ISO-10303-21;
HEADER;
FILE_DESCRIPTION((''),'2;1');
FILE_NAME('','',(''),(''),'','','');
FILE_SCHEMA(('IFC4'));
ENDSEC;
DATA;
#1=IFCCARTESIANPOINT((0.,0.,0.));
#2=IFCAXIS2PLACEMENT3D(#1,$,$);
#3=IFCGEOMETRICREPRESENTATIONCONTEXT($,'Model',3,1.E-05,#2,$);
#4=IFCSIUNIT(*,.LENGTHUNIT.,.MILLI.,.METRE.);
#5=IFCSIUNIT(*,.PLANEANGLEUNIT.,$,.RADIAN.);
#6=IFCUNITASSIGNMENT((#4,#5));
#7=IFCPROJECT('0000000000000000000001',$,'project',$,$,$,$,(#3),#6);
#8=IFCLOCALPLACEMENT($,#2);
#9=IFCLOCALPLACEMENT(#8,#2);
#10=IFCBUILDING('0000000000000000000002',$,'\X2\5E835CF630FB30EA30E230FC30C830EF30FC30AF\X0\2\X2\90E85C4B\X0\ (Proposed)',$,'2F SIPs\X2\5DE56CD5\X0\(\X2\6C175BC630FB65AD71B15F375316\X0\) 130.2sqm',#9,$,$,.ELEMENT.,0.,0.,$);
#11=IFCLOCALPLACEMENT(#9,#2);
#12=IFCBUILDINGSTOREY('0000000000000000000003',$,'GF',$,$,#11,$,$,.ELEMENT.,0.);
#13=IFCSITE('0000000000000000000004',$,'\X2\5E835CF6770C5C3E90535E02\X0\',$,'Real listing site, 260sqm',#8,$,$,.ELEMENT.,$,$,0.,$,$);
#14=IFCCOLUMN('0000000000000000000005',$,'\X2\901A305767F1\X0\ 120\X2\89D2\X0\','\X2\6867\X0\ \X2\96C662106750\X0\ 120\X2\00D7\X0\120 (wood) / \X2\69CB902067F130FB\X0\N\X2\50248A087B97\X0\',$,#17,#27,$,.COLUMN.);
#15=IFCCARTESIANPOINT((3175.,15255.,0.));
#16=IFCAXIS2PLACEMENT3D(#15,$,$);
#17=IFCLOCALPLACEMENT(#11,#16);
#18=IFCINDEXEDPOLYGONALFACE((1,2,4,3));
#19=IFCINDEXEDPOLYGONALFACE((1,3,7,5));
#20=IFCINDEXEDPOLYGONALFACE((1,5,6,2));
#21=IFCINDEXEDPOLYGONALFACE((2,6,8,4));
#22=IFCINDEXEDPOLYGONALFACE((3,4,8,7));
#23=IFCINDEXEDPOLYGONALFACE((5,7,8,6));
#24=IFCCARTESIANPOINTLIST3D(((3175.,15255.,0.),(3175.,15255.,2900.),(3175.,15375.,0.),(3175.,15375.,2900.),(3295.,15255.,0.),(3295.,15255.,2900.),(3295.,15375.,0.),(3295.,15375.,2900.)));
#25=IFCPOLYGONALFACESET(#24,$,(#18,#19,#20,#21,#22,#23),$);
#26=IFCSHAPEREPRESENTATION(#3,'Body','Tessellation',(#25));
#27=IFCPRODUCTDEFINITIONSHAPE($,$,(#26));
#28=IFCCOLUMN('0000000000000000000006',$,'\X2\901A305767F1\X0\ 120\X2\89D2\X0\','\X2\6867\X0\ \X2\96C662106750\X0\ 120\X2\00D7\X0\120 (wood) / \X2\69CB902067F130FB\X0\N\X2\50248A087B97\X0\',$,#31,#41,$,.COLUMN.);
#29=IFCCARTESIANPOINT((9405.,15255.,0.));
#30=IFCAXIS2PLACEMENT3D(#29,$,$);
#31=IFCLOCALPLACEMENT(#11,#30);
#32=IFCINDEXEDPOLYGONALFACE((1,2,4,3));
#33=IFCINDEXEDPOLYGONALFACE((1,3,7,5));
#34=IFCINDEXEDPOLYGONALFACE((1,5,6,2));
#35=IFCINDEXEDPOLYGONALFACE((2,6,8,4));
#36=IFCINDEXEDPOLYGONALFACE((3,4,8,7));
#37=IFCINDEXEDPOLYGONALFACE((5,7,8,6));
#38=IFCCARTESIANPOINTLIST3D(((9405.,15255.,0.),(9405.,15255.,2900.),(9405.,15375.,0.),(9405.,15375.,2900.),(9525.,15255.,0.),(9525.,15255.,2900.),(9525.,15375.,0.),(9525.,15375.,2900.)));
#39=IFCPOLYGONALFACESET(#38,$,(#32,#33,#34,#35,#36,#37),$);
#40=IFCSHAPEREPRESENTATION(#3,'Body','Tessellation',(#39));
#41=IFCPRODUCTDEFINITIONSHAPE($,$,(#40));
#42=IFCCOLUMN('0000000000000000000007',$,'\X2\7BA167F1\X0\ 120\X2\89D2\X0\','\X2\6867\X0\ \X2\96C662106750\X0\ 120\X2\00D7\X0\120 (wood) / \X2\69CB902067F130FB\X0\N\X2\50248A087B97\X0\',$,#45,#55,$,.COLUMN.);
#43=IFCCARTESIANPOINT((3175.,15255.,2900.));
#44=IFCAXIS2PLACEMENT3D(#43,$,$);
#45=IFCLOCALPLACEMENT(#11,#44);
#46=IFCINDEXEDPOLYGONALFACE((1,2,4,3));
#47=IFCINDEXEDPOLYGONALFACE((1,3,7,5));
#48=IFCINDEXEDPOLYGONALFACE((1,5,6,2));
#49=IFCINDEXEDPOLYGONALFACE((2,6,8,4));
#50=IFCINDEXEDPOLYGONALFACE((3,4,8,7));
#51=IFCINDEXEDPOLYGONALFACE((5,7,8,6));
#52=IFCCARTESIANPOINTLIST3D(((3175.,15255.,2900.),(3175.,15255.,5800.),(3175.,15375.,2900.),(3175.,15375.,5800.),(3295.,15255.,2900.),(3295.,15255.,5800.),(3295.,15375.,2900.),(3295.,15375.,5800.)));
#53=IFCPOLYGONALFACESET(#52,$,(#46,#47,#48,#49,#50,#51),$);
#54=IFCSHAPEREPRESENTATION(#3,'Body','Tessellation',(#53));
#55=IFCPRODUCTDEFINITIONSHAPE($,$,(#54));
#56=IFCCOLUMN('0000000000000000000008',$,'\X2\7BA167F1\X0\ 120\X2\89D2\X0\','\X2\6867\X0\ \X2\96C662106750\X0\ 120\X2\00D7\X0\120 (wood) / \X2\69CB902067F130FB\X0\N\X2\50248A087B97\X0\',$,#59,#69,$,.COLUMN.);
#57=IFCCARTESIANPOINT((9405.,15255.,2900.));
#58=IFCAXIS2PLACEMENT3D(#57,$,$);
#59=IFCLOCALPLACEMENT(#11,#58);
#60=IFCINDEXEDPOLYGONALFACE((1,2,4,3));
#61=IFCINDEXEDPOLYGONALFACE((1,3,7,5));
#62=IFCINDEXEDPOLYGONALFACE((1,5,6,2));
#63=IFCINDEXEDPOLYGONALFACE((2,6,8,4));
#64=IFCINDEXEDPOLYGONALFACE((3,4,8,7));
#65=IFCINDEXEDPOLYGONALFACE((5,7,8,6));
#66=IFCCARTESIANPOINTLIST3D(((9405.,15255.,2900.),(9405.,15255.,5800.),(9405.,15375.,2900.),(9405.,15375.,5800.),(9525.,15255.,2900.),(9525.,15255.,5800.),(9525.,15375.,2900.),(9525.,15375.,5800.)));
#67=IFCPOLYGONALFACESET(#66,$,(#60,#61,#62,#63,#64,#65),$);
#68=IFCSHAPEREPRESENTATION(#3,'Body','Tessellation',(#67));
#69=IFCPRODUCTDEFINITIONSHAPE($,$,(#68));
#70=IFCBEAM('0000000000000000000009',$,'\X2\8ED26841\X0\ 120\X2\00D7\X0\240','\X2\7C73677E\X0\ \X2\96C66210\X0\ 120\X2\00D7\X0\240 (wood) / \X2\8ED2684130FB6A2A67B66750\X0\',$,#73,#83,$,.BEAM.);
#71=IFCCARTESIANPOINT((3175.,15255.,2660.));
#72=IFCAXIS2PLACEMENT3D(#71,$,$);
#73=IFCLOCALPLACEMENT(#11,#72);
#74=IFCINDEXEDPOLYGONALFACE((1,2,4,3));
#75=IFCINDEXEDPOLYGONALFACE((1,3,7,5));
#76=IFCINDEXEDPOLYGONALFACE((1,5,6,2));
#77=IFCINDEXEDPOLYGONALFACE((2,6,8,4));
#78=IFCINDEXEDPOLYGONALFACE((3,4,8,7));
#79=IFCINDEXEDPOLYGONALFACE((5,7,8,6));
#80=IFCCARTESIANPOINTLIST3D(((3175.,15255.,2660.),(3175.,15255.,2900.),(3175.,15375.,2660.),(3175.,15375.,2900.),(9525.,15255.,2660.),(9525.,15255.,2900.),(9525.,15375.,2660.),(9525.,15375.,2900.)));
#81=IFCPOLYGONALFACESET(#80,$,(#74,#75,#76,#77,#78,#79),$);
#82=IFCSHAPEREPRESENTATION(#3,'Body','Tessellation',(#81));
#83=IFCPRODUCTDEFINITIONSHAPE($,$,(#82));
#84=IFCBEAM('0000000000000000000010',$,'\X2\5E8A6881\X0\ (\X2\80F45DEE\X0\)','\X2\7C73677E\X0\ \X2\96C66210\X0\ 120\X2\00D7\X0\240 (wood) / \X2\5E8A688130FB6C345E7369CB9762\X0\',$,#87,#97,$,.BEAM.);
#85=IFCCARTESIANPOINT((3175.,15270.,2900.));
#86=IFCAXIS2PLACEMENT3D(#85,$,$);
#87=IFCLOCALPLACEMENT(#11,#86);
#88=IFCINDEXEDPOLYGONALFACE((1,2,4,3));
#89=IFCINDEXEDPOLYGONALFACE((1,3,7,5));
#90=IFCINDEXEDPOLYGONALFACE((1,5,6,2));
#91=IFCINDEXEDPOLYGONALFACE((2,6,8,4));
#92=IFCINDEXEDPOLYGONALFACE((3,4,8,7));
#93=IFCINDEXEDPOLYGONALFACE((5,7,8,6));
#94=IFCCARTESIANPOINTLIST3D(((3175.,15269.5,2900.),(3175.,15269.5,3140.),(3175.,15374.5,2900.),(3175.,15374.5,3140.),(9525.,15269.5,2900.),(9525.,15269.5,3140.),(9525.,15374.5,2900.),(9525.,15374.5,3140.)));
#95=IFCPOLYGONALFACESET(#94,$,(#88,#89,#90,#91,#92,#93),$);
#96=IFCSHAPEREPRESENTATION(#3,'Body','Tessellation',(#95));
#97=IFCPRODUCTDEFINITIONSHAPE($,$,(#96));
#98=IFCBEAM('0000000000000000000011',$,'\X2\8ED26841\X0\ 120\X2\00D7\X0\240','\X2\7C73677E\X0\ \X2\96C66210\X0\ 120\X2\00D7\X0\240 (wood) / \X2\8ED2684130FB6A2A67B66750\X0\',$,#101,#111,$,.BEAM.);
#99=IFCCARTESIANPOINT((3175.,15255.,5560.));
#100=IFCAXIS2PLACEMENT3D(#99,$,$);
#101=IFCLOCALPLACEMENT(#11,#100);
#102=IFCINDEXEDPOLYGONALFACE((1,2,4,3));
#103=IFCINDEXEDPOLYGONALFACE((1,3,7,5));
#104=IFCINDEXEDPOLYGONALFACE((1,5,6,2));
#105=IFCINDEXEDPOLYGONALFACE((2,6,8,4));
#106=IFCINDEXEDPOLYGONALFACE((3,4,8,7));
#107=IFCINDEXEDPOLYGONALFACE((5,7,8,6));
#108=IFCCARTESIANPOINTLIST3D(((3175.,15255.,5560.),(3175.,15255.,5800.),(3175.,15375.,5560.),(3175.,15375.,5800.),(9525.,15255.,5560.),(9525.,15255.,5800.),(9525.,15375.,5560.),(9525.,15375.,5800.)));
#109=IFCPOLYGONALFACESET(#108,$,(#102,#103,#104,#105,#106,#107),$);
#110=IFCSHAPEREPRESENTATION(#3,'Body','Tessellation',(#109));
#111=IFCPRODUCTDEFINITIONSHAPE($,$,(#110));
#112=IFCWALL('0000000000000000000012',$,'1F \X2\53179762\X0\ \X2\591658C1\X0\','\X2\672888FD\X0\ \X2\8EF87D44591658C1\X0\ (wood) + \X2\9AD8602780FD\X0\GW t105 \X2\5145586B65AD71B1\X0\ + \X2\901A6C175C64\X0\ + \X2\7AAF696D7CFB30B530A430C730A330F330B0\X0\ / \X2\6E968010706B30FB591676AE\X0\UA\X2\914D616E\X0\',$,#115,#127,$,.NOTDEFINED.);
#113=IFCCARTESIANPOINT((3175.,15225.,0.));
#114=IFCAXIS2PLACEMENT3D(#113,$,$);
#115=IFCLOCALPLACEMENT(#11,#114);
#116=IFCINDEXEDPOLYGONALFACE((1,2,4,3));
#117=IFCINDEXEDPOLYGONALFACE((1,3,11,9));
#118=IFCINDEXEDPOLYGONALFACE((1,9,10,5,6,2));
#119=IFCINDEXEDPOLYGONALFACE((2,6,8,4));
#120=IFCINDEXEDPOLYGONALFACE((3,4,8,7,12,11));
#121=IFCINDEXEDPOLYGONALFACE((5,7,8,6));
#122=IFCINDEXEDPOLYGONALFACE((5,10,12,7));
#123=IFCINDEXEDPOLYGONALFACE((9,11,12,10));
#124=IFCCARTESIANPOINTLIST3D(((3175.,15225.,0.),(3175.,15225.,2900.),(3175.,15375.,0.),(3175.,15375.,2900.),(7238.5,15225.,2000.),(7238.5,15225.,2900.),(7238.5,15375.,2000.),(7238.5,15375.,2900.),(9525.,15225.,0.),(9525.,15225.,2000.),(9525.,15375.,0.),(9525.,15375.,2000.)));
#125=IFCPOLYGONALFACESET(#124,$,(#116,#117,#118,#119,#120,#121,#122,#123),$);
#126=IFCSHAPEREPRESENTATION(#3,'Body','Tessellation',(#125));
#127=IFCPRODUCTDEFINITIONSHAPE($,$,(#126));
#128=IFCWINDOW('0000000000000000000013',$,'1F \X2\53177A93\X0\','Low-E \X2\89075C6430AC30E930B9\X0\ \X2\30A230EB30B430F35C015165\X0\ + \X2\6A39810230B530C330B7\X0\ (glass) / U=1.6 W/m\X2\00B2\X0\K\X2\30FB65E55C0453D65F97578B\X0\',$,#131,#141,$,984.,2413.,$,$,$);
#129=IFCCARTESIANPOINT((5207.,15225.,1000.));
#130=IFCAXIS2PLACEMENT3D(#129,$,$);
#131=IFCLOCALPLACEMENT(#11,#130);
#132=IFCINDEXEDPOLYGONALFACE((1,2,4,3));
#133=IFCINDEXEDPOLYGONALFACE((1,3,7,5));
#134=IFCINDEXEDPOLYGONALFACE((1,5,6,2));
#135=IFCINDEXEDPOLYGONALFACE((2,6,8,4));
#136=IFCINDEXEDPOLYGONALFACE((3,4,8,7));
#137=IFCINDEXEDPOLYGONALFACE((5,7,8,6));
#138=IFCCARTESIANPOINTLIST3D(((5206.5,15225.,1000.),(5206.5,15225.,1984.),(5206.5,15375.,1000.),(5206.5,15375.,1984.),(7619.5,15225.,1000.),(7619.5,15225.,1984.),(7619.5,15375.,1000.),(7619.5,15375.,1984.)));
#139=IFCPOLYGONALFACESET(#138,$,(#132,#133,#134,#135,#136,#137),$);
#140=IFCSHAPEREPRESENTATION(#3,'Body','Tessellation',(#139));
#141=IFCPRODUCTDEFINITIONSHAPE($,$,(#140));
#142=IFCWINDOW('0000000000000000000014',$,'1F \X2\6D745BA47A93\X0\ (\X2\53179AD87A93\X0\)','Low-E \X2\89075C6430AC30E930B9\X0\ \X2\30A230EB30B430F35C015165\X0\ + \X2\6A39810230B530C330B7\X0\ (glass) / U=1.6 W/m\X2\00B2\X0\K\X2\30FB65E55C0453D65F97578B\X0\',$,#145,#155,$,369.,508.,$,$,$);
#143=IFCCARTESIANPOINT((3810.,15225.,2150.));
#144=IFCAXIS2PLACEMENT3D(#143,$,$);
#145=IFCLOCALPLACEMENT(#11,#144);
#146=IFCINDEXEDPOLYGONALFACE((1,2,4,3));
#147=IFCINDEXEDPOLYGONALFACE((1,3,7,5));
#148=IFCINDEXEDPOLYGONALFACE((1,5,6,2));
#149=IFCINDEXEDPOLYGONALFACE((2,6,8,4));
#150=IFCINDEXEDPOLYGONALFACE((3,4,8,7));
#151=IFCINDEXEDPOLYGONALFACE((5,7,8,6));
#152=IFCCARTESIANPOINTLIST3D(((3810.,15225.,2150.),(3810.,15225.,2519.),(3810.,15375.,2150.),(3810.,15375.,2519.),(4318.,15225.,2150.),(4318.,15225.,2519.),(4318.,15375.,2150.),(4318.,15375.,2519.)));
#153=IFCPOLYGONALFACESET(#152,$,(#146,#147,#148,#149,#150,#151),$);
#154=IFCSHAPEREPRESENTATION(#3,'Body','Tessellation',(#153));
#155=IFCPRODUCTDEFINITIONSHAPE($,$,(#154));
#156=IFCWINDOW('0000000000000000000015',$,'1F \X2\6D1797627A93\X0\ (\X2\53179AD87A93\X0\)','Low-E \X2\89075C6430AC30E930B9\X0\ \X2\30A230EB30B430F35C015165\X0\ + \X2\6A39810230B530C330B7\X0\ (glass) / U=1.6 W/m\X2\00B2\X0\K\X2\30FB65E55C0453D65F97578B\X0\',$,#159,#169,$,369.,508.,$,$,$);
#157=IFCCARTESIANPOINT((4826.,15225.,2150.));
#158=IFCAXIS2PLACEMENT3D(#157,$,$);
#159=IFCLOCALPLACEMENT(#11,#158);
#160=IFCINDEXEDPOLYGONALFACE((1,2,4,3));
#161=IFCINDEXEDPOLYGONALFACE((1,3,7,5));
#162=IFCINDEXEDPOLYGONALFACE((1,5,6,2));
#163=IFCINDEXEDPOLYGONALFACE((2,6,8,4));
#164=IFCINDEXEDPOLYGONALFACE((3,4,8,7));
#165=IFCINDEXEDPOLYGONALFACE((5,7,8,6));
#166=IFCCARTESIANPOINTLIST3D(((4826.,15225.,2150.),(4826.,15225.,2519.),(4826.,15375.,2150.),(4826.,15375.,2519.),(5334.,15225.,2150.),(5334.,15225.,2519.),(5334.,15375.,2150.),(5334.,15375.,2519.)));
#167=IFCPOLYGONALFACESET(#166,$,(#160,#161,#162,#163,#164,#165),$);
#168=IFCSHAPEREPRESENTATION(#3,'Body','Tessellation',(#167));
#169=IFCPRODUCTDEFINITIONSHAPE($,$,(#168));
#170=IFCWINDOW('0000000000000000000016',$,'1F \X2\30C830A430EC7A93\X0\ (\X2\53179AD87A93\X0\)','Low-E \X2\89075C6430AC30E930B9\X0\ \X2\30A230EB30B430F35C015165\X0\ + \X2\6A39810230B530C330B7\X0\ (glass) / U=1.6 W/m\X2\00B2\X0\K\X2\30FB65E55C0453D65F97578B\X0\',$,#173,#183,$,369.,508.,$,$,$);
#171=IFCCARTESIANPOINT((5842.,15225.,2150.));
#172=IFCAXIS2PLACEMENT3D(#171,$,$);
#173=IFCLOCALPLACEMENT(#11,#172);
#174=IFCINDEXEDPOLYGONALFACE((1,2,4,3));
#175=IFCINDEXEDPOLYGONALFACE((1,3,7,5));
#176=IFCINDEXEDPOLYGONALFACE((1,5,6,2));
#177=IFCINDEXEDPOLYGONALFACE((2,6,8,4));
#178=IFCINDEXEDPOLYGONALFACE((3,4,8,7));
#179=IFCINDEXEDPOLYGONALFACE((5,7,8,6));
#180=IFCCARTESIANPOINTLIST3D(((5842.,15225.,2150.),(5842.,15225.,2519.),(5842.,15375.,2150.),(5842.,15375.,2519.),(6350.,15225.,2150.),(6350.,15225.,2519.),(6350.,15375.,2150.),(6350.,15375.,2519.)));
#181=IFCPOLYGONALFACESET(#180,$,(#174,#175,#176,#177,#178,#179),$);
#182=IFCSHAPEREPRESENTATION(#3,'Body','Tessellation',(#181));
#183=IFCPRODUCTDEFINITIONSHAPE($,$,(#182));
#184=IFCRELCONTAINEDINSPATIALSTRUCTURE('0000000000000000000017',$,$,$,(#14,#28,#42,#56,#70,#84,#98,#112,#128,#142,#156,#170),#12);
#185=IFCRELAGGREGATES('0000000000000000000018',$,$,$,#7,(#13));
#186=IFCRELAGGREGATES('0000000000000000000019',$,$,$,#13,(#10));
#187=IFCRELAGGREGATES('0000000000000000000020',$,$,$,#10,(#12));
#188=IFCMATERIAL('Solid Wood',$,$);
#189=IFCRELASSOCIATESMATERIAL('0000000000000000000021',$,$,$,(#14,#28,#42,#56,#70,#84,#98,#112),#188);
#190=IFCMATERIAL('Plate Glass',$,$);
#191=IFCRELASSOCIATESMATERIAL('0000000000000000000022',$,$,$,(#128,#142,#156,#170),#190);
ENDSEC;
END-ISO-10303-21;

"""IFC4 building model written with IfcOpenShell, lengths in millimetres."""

from ifc_helpers import new_model, si_unit, frame, frame_2d, origin, place, context, project, spatial, rectangle, extrude, material, element, fill, save


model = new_model("IFC4")

# Units and contexts
model_context = context("Model", 3, precision=1e-05, world=origin())
ifc_project = project(units=[si_unit("LENGTHUNIT", "METRE", prefix="MILLI"), si_unit("PLANEANGLEUNIT", "RADIAN")], contexts=[model_context])

# Site, building, storey
site_placement = place(None, origin())
site = spatial("IfcSite", under=ifc_project, at=site_placement, Name="広島県尾道市", ObjectType="Real listing site, 260sqm", CompositionType="ELEMENT", RefElevation=0.0)
building_placement = place(site_placement, origin())
building = spatial("IfcBuilding", under=site, at=building_placement, Name="広島・リモートワーク2部屋 (Proposed)", ObjectType="2F SIPs工法(気密・断熱強化) 130.2sqm", CompositionType="ELEMENT", ElevationOfRefHeight=0.0, ElevationOfTerrain=0.0)
storey_placement = place(building_placement, origin())
storey = spatial("IfcBuildingStorey", under=building, at=storey_placement, Name="GF", CompositionType="ELEMENT", Elevation=0.0)

# Columns
ifc_material_1 = material(Name="Solid Wood")
column_1_placement = place(storey_placement, frame((3175.0, 15255.0, 0.0)))
element("IfcColumn", 1, at=column_1_placement, inside=storey, material=ifc_material_1, Name="通し柱 120角", Description="桧 集成材 120×120 (wood) / 構造柱・N値計算", PredefinedType="COLUMN", context=model_context, shape_type="SweptSolid", body=[
    extrude(rectangle(XDim=120.0, YDim=120.0, at=frame_2d((60.0, 60.0))), frame((3175.0, 15255.0, 0.0)), (0.0, 0.0, 1.0), 2900.0),
])
column_2_placement = place(storey_placement, frame((9405.0, 15255.0, 0.0)))
element("IfcColumn", 2, at=column_2_placement, inside=storey, material=ifc_material_1, Name="通し柱 120角", Description="桧 集成材 120×120 (wood) / 構造柱・N値計算", PredefinedType="COLUMN", context=model_context, shape_type="SweptSolid", body=[
    extrude(rectangle(XDim=120.0, YDim=120.0, at=frame_2d((60.0, 60.0))), frame((9405.0, 15255.0, 0.0)), (0.0, 0.0, 1.0), 2900.0),
])
column_3_placement = place(storey_placement, frame((3175.0, 15255.0, 2900.0)))
element("IfcColumn", 3, at=column_3_placement, inside=storey, material=ifc_material_1, Name="管柱 120角", Description="桧 集成材 120×120 (wood) / 構造柱・N値計算", PredefinedType="COLUMN", context=model_context, shape_type="SweptSolid", body=[
    extrude(rectangle(XDim=120.0, YDim=120.0, at=frame_2d((60.0, 60.0))), frame((3175.0, 15255.0, 2900.0)), (0.0, 0.0, 1.0), 2900.0),
])
column_4_placement = place(storey_placement, frame((9405.0, 15255.0, 2900.0)))
element("IfcColumn", 4, at=column_4_placement, inside=storey, material=ifc_material_1, Name="管柱 120角", Description="桧 集成材 120×120 (wood) / 構造柱・N値計算", PredefinedType="COLUMN", context=model_context, shape_type="SweptSolid", body=[
    extrude(rectangle(XDim=120.0, YDim=120.0, at=frame_2d((60.0, 60.0))), frame((9405.0, 15255.0, 2900.0)), (0.0, 0.0, 1.0), 2900.0),
])

# Beams
beam_1_placement = place(storey_placement, frame((3175.0, 15255.0, 2660.0)))
element("IfcBeam", 5, at=beam_1_placement, inside=storey, material=ifc_material_1, Name="軒桁 120×240", Description="米松 集成 120×240 (wood) / 軒桁・横架材", PredefinedType="BEAM", context=model_context, shape_type="SweptSolid", body=[
    extrude(rectangle(XDim=6350.0, YDim=120.0, at=frame_2d((3175.0, 60.0))), frame((3175.0, 15255.0, 2660.0)), (0.0, 0.0, 1.0), 240.0),
])
beam_2_placement = place(storey_placement, frame((3175.0, 15270.0, 2900.0)))
element("IfcBeam", 6, at=beam_2_placement, inside=storey, material=ifc_material_1, Name="床梁 (胴差)", Description="米松 集成 120×240 (wood) / 床梁・水平構面", PredefinedType="BEAM", context=model_context, shape_type="SweptSolid", body=[
    extrude(rectangle(XDim=6350.0, YDim=105.0, at=frame_2d((3175.0, 52.0))), frame((3175.0, 15270.0, 2900.0)), (0.0, 0.0, 1.0), 240.0),
])
beam_3_placement = place(storey_placement, frame((3175.0, 15255.0, 5560.0)))
element("IfcBeam", 7, at=beam_3_placement, inside=storey, material=ifc_material_1, Name="軒桁 120×240", Description="米松 集成 120×240 (wood) / 軒桁・横架材", PredefinedType="BEAM", context=model_context, shape_type="SweptSolid", body=[
    extrude(rectangle(XDim=6350.0, YDim=120.0, at=frame_2d((3175.0, 60.0))), frame((3175.0, 15255.0, 5560.0)), (0.0, 0.0, 1.0), 240.0),
])

# Wall, openings, windows
wall_1_placement = place(storey_placement, frame((3175.0, 15225.0, 0.0)))
wall_1 = element("IfcWall", 8, at=wall_1_placement, inside=storey, material=ifc_material_1, Name="1F 北面 外壁", Description="木製 軸組外壁 (wood) + 高性能GW t105 充填断熱 + 通気層 + 窯業系サイディング / 準耐火・外皮UA配慮", PredefinedType="NOTDEFINED", context=model_context, shape_type="SweptSolid", body=[
    extrude(rectangle(XDim=6350.0, YDim=150.0, at=frame_2d((3175.0, 75.0))), frame((3175.0, 15225.0, 0.0)), (0.0, 0.0, 1.0), 2900.0),
])
opening_1_placement = place(storey_placement, frame((5207.0, 15225.0, 1000.0)))
opening_1 = element("IfcOpeningElement", 9, at=opening_1_placement, cuts=wall_1, PredefinedType="NOTDEFINED", context=model_context, shape_type="SweptSolid", body=[
    extrude(rectangle(XDim=2413.0, YDim=150.0, at=frame_2d((1206.0, 75.0))), frame((5207.0, 15225.0, 1000.0)), (0.0, 0.0, 1.0), 984.0),
])
opening_2_placement = place(storey_placement, frame((3810.0, 15225.0, 2150.0)))
opening_2 = element("IfcOpeningElement", 10, at=opening_2_placement, cuts=wall_1, PredefinedType="NOTDEFINED", context=model_context, shape_type="SweptSolid", body=[
    extrude(rectangle(XDim=508.0, YDim=150.0, at=frame_2d((254.0, 75.0))), frame((3810.0, 15225.0, 2150.0)), (0.0, 0.0, 1.0), 369.0),
])
opening_3_placement = place(storey_placement, frame((4826.0, 15225.0, 2150.0)))
opening_3 = element("IfcOpeningElement", 11, at=opening_3_placement, cuts=wall_1, PredefinedType="NOTDEFINED", context=model_context, shape_type="SweptSolid", body=[
    extrude(rectangle(XDim=508.0, YDim=150.0, at=frame_2d((254.0, 75.0))), frame((4826.0, 15225.0, 2150.0)), (0.0, 0.0, 1.0), 369.0),
])
opening_4_placement = place(storey_placement, frame((5842.0, 15225.0, 2150.0)))
opening_4 = element("IfcOpeningElement", 12, at=opening_4_placement, cuts=wall_1, PredefinedType="NOTDEFINED", context=model_context, shape_type="SweptSolid", body=[
    extrude(rectangle(XDim=508.0, YDim=150.0, at=frame_2d((254.0, 75.0))), frame((5842.0, 15225.0, 2150.0)), (0.0, 0.0, 1.0), 369.0),
])
ifc_material_2 = material(Name="Plate Glass")
window_1_placement = place(storey_placement, frame((5207.0, 15225.0, 1000.0)))
window_1 = element("IfcWindow", 13, at=window_1_placement, inside=storey, material=ifc_material_2, Name="1F 北窓", Description="Low-E 複層ガラス アルゴン封入 + 樹脂サッシ (glass) / U=1.6 W/m²K・日射取得型", OverallHeight=984.0, OverallWidth=2413.0, context=model_context, shape_type="SweptSolid", body=[
    extrude(rectangle(XDim=2413.0, YDim=150.0, at=frame_2d((1206.0, 75.0))), frame((5207.0, 15225.0, 1000.0)), (0.0, 0.0, 1.0), 984.0),
])
fill(opening_1, window_1)
window_2_placement = place(storey_placement, frame((3810.0, 15225.0, 2150.0)))
window_2 = element("IfcWindow", 14, at=window_2_placement, inside=storey, material=ifc_material_2, Name="1F 浴室窓 (北高窓)", Description="Low-E 複層ガラス アルゴン封入 + 樹脂サッシ (glass) / U=1.6 W/m²K・日射取得型", OverallHeight=369.0, OverallWidth=508.0, context=model_context, shape_type="SweptSolid", body=[
    extrude(rectangle(XDim=508.0, YDim=150.0, at=frame_2d((254.0, 75.0))), frame((3810.0, 15225.0, 2150.0)), (0.0, 0.0, 1.0), 369.0),
])
fill(opening_2, window_2)
window_3_placement = place(storey_placement, frame((4826.0, 15225.0, 2150.0)))
window_3 = element("IfcWindow", 15, at=window_3_placement, inside=storey, material=ifc_material_2, Name="1F 洗面窓 (北高窓)", Description="Low-E 複層ガラス アルゴン封入 + 樹脂サッシ (glass) / U=1.6 W/m²K・日射取得型", OverallHeight=369.0, OverallWidth=508.0, context=model_context, shape_type="SweptSolid", body=[
    extrude(rectangle(XDim=508.0, YDim=150.0, at=frame_2d((254.0, 75.0))), frame((4826.0, 15225.0, 2150.0)), (0.0, 0.0, 1.0), 369.0),
])
fill(opening_3, window_3)
window_4_placement = place(storey_placement, frame((5842.0, 15225.0, 2150.0)))
window_4 = element("IfcWindow", 16, at=window_4_placement, inside=storey, material=ifc_material_2, Name="1F トイレ窓 (北高窓)", Description="Low-E 複層ガラス アルゴン封入 + 樹脂サッシ (glass) / U=1.6 W/m²K・日射取得型", OverallHeight=369.0, OverallWidth=508.0, context=model_context, shape_type="SweptSolid", body=[
    extrude(rectangle(XDim=508.0, YDim=150.0, at=frame_2d((254.0, 75.0))), frame((5842.0, 15225.0, 2150.0)), (0.0, 0.0, 1.0), 369.0),
])
fill(opening_4, window_4)

save(model, "model.ifc")
